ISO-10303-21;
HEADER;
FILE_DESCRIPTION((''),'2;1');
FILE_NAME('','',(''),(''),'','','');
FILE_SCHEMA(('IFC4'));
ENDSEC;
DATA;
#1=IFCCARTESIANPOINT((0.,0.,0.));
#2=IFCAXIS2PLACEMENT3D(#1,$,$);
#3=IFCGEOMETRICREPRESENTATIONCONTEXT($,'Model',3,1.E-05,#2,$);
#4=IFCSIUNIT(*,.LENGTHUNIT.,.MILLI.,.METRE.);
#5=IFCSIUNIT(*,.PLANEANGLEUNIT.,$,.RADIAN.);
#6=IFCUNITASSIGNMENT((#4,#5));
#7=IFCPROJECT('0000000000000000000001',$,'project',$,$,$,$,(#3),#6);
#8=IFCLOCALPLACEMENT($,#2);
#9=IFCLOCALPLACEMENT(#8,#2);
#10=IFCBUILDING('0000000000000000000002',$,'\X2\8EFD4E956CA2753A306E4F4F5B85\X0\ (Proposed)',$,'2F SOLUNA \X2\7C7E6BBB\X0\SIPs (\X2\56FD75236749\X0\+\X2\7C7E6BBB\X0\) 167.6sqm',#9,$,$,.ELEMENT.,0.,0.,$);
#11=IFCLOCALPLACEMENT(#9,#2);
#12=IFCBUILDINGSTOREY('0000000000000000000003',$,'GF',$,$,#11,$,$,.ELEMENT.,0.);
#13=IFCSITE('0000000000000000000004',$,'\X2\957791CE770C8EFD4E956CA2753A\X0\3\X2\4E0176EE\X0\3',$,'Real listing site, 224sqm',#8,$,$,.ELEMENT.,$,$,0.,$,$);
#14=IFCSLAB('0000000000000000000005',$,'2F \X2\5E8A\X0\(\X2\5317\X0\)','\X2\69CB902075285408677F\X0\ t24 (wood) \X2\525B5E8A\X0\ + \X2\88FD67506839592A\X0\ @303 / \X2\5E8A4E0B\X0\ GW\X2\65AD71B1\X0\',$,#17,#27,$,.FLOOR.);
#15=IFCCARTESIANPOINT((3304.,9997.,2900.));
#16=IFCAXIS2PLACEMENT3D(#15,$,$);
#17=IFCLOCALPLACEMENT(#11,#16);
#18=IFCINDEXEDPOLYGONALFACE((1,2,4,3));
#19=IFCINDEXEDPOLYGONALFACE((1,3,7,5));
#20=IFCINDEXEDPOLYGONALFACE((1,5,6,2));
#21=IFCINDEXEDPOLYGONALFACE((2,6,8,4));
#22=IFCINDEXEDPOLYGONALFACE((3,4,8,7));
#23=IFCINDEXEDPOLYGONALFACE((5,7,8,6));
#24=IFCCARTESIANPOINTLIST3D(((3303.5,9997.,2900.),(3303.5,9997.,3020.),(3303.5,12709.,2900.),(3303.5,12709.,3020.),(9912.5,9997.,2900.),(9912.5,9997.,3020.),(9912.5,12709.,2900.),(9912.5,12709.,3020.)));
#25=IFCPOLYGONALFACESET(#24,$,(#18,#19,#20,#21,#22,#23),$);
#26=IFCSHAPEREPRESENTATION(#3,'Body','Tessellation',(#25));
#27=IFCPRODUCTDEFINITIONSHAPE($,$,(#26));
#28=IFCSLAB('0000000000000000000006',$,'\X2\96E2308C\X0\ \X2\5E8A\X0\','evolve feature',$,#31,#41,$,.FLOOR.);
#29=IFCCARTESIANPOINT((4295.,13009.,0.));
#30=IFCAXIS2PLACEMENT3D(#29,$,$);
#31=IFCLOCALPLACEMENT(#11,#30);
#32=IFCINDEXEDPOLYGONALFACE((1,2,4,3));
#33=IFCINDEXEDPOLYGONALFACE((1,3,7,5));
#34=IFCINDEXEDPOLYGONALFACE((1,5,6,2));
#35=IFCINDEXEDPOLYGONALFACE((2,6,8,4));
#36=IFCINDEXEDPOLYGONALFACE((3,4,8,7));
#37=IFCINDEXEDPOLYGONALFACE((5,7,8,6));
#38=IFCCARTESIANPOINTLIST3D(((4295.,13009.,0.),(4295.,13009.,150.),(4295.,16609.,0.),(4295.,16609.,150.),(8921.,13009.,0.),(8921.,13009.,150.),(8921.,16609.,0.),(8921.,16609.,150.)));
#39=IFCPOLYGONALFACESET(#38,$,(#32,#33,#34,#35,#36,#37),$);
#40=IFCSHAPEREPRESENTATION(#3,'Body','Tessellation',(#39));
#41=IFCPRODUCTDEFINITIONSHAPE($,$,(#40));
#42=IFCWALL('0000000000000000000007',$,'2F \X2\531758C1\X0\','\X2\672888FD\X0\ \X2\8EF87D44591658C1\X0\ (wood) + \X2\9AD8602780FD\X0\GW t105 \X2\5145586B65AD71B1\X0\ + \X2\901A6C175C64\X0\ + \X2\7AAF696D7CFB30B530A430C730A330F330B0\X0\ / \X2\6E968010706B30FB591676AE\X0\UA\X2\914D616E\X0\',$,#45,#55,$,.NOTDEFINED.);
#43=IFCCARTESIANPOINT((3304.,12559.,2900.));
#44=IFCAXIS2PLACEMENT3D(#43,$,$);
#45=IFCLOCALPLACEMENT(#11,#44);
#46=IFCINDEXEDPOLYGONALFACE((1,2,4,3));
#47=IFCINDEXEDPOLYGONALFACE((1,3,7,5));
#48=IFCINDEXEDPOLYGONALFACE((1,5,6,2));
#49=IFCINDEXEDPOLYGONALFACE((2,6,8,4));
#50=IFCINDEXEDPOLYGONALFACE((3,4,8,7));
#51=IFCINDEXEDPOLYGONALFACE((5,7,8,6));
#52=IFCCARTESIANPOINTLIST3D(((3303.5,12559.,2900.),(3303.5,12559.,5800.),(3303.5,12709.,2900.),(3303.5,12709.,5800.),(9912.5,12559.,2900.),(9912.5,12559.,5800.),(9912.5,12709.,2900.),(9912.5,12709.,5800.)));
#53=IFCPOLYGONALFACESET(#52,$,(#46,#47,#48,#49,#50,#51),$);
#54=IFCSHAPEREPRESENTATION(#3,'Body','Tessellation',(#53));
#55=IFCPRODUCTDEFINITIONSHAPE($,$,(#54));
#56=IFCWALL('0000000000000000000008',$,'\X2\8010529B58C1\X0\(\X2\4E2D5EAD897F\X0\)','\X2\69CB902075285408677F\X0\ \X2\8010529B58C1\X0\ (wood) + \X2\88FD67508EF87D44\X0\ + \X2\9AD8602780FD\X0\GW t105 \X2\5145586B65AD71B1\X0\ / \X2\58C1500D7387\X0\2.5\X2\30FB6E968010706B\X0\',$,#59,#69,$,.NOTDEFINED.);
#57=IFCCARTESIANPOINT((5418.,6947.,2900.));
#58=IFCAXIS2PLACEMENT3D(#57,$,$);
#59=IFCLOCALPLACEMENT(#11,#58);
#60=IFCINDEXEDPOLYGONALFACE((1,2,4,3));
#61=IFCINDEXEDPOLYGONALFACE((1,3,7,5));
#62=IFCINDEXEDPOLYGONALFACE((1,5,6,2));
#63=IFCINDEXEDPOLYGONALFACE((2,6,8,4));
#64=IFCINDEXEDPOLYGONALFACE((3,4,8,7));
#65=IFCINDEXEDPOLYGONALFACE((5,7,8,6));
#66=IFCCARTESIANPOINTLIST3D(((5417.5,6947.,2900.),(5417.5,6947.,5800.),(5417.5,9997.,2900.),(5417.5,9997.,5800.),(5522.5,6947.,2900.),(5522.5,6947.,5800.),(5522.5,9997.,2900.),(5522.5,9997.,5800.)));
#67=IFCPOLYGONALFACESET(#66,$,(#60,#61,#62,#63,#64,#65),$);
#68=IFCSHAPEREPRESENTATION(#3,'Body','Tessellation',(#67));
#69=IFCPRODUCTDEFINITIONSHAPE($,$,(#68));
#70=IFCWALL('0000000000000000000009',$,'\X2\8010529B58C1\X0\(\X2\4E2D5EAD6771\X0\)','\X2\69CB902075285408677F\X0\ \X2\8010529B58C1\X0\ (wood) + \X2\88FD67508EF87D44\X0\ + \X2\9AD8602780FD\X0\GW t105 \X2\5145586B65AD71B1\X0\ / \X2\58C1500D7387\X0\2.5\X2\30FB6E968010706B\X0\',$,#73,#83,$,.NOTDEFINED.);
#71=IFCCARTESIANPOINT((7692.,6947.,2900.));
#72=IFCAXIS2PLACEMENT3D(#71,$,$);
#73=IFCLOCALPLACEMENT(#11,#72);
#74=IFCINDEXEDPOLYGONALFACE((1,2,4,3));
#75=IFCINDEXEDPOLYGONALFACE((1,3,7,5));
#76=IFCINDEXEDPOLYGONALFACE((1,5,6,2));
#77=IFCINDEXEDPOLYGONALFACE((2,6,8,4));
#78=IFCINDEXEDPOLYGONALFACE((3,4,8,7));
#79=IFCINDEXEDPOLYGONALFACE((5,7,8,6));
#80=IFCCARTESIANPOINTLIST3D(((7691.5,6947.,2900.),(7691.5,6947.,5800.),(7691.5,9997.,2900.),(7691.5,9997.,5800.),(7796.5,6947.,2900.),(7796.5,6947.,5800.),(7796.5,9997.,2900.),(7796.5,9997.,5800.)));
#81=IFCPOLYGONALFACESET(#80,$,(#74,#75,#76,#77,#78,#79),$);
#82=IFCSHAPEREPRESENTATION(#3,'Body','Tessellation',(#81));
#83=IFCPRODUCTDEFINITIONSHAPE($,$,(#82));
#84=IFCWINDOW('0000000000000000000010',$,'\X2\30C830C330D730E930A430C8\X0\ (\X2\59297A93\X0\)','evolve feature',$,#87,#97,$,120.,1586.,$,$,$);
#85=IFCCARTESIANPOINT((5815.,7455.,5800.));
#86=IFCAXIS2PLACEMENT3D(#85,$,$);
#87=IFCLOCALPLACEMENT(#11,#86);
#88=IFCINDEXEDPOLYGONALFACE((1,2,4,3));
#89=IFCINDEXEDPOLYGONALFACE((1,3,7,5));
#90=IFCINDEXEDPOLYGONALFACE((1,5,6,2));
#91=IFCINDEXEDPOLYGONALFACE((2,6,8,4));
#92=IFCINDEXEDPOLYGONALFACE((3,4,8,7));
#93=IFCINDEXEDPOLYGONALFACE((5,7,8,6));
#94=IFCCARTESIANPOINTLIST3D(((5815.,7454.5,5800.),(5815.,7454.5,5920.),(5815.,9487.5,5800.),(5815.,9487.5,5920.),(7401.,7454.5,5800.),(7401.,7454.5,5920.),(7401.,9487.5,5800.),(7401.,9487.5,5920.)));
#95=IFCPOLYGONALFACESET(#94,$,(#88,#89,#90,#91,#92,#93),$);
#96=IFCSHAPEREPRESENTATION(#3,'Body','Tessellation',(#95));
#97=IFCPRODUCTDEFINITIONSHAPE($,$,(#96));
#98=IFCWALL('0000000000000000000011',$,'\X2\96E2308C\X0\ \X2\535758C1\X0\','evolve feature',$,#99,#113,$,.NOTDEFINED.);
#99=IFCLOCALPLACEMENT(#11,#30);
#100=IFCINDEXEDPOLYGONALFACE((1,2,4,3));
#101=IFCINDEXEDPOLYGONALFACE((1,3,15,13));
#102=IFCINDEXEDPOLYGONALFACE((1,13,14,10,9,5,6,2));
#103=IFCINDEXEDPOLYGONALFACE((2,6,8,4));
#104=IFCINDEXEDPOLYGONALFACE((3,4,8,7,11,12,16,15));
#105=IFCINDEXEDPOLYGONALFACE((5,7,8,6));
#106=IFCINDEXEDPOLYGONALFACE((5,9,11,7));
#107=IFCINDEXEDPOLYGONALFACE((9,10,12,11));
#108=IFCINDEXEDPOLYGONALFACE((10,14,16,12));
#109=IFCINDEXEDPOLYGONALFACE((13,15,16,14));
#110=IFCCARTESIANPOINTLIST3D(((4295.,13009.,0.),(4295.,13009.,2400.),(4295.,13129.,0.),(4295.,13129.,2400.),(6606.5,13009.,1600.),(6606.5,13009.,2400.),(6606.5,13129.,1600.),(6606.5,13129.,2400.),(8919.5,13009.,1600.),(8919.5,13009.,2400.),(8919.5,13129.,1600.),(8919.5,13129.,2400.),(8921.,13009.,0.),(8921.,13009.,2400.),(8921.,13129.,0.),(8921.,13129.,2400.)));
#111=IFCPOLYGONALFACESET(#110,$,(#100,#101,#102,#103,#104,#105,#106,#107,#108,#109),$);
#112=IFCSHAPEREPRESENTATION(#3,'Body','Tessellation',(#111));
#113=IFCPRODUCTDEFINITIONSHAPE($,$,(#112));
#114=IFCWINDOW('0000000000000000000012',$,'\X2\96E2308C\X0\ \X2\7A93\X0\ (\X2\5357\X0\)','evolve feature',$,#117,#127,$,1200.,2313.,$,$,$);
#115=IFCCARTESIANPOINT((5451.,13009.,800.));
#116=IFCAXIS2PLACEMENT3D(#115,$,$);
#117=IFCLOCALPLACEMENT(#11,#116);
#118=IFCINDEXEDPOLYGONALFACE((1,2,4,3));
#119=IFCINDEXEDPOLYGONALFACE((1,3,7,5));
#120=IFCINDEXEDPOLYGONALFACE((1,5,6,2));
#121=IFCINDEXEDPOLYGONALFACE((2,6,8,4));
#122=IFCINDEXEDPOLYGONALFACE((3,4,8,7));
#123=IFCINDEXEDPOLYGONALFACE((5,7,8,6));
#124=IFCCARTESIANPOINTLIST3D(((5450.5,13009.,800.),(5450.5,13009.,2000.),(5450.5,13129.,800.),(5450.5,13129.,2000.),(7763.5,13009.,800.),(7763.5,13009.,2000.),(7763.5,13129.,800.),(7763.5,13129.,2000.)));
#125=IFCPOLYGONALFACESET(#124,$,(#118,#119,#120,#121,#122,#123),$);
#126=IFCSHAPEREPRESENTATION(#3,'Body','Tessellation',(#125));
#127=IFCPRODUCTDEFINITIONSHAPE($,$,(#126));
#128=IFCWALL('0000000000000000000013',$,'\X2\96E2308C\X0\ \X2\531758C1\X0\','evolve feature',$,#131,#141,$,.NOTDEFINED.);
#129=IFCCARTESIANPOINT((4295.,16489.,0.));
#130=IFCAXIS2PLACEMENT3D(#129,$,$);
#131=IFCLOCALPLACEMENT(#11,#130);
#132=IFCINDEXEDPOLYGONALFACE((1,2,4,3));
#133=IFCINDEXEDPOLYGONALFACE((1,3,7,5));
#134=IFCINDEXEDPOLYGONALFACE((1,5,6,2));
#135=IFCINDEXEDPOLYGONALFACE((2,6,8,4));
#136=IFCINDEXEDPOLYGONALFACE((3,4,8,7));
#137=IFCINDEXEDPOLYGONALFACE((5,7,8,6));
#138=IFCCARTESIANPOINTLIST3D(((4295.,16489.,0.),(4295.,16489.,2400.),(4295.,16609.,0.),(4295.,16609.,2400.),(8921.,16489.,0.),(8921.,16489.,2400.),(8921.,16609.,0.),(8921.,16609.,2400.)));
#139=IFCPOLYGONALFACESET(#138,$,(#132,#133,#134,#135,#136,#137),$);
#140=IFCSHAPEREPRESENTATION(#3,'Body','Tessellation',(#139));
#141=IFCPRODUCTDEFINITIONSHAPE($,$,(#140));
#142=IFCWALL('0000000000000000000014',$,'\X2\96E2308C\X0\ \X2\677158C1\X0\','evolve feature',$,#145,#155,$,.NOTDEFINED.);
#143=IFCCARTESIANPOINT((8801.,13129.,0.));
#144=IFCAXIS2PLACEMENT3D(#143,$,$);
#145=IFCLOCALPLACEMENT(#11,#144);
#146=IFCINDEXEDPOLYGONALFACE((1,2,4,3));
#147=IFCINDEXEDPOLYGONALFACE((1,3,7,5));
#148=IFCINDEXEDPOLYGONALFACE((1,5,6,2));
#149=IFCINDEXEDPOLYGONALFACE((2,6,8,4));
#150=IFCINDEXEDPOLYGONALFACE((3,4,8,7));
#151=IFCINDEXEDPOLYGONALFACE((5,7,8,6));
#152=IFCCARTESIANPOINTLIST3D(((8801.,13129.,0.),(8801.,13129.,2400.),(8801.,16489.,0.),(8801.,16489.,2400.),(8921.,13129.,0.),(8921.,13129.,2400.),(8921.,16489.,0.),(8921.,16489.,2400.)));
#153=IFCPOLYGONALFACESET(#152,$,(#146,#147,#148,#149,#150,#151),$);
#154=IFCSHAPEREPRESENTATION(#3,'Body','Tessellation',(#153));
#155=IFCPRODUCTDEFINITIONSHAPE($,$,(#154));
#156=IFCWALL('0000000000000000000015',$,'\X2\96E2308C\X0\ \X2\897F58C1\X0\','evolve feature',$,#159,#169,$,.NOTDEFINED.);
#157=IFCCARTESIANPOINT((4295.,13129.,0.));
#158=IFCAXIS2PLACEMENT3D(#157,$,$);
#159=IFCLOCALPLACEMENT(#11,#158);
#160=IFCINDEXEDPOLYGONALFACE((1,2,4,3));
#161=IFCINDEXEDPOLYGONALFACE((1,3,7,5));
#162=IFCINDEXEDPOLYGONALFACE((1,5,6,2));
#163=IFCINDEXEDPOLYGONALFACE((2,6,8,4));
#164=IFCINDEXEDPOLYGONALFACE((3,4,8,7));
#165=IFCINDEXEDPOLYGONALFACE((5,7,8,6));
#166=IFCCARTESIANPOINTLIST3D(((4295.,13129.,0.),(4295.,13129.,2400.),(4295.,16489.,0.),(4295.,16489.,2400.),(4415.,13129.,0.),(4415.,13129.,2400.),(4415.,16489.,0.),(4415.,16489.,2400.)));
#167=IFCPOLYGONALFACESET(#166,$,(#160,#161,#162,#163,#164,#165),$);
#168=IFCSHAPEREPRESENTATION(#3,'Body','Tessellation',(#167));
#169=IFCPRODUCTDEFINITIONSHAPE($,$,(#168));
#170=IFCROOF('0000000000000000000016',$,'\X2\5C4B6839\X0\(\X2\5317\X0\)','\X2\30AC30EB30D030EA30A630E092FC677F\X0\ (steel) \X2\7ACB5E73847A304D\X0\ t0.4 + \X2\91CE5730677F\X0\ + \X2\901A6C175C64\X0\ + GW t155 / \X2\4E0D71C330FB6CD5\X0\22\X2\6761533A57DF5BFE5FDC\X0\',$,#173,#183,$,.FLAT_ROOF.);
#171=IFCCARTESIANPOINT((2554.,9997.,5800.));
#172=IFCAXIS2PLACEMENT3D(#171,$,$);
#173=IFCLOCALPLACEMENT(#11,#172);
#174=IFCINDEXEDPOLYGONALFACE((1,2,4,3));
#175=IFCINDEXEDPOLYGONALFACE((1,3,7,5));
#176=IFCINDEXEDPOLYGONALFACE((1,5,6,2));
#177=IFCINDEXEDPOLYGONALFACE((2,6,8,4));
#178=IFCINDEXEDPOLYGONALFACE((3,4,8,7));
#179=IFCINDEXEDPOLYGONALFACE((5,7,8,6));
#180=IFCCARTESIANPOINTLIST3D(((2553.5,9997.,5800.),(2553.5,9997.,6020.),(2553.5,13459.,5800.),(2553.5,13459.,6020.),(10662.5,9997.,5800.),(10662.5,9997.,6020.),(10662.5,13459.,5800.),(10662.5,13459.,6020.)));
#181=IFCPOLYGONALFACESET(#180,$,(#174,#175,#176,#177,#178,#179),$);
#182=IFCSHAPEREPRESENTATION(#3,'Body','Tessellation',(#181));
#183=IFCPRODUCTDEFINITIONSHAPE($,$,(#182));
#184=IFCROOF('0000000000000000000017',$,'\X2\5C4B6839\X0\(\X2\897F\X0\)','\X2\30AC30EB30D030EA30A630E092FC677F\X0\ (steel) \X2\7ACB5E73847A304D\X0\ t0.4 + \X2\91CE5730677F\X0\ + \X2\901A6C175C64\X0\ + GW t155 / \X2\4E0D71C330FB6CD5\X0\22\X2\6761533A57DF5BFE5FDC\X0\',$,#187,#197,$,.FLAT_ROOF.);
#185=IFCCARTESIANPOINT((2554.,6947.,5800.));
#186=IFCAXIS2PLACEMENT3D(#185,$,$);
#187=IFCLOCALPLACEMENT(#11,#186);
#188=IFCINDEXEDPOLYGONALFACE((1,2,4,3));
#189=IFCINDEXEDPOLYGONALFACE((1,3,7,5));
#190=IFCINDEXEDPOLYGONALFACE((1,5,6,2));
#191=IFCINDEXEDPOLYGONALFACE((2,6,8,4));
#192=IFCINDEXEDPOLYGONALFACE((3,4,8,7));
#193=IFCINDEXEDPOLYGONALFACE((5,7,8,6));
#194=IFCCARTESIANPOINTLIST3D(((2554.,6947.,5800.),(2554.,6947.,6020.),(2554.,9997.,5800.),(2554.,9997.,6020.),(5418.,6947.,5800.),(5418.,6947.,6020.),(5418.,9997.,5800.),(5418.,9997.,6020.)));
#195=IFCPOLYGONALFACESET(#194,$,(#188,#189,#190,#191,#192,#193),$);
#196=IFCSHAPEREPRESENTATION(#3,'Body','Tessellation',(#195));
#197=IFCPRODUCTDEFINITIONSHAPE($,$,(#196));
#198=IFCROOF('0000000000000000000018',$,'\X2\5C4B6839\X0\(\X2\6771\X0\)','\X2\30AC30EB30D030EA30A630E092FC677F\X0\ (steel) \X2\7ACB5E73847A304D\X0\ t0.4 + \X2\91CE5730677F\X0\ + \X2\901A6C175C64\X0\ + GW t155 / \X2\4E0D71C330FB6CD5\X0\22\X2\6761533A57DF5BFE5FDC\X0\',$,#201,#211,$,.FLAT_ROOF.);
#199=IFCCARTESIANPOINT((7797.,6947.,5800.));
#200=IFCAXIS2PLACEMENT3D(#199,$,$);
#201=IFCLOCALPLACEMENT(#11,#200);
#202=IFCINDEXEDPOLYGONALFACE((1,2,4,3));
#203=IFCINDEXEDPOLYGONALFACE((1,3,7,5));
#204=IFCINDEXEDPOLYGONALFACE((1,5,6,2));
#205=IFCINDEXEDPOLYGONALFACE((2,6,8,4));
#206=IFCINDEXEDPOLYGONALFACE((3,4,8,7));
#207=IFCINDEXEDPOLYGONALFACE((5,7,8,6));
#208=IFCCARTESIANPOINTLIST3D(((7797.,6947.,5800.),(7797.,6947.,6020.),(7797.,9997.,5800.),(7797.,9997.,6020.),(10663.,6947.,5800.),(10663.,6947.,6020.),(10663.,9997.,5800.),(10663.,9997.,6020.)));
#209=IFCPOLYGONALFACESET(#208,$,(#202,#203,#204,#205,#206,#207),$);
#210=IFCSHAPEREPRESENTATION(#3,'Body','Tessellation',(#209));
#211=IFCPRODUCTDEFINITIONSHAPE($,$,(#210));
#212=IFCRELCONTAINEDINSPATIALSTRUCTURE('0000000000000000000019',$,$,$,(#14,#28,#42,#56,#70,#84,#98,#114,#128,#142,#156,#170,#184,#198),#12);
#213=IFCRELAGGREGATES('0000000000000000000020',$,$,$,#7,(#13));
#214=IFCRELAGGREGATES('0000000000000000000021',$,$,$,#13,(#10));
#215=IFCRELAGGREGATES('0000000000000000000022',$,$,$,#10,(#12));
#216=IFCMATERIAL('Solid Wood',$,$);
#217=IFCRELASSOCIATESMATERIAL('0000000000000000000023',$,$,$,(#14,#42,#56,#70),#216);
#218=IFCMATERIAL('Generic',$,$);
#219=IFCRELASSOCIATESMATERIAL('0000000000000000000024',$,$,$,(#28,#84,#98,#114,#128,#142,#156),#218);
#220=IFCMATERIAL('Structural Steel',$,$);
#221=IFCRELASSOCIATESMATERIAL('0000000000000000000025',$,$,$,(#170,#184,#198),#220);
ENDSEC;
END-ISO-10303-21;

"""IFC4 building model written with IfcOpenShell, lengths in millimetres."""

from ifc_helpers import new_model, si_unit, frame, frame_2d, origin, place, context, project, spatial, rectangle, extrude, material, element, fill, save


model = new_model("IFC4")

# Units and contexts
model_context = context("Model", 3, precision=1e-05, world=origin())
ifc_project = project(units=[si_unit("LENGTHUNIT", "METRE", prefix="MILLI"), si_unit("PLANEANGLEUNIT", "RADIAN")], contexts=[model_context])

# Site, building, storey
site_placement = place(None, origin())
site = spatial("IfcSite", under=ifc_project, at=site_placement, Name="長野県軽井沢町3丁目3", ObjectType="Real listing site, 224sqm", CompositionType="ELEMENT", RefElevation=0.0)
building_placement = place(site_placement, origin())
building = spatial("IfcBuilding", under=site, at=building_placement, Name="軽井沢町の住宅 (Proposed)", ObjectType="2F SOLUNA 籾殻SIPs (国産杉+籾殻) 167.6sqm", CompositionType="ELEMENT", ElevationOfRefHeight=0.0, ElevationOfTerrain=0.0)
storey_placement = place(building_placement, origin())
storey = spatial("IfcBuildingStorey", under=building, at=storey_placement, Name="GF", CompositionType="ELEMENT", Elevation=0.0)

# Slabs
ifc_material_1 = material(Name="Solid Wood")
slab_1_placement = place(storey_placement, frame((3304.0, 9997.0, 2900.0)))
element("IfcSlab", 1, at=slab_1_placement, inside=storey, material=ifc_material_1, Name="2F 床(北)", Description="構造用合板 t24 (wood) 剛床 + 製材根太 @303 / 床下 GW断熱", PredefinedType="FLOOR", context=model_context, shape_type="SweptSolid", body=[
    extrude(rectangle(XDim=6609.0, YDim=2712.0, at=frame_2d((3304.0, 1356.0))), frame((3304.0, 9997.0, 2900.0)), (0.0, 0.0, 1.0), 120.0),
])
ifc_material_2 = material(Name="Generic")
slab_2_placement = place(storey_placement, frame((4295.0, 13009.0, 0.0)))
element("IfcSlab", 2, at=slab_2_placement, inside=storey, material=ifc_material_2, Name="離れ 床", Description="evolve feature", PredefinedType="FLOOR", context=model_context, shape_type="SweptSolid", body=[
    extrude(rectangle(XDim=4626.0, YDim=3600.0, at=frame_2d((2313.0, 1800.0))), frame((4295.0, 13009.0, 0.0)), (0.0, 0.0, 1.0), 150.0),
])

# Wall
wall_1_placement = place(storey_placement, frame((3304.0, 12559.0, 2900.0)))
element("IfcWall", 3, at=wall_1_placement, inside=storey, material=ifc_material_1, Name="2F 北壁", Description="木製 軸組外壁 (wood) + 高性能GW t105 充填断熱 + 通気層 + 窯業系サイディング / 準耐火・外皮UA配慮", PredefinedType="NOTDEFINED", context=model_context, shape_type="SweptSolid", body=[
    extrude(rectangle(XDim=6609.0, YDim=150.0, at=frame_2d((3304.0, 75.0))), frame((3304.0, 12559.0, 2900.0)), (0.0, 0.0, 1.0), 2900.0),
])

# Walls
wall_2_placement = place(storey_placement, frame((5418.0, 6947.0, 2900.0)))
element("IfcWall", 4, at=wall_2_placement, inside=storey, material=ifc_material_1, Name="耐力壁(中庭西)", Description="構造用合板 耐力壁 (wood) + 製材軸組 + 高性能GW t105 充填断熱 / 壁倍率2.5・準耐火", PredefinedType="NOTDEFINED", context=model_context, shape_type="SweptSolid", body=[
    extrude(rectangle(XDim=105.0, YDim=3050.0, at=frame_2d((52.0, 1525.0))), frame((5418.0, 6947.0, 2900.0)), (0.0, 0.0, 1.0), 2900.0),
])
wall_3_placement = place(storey_placement, frame((7692.0, 6947.0, 2900.0)))
element("IfcWall", 5, at=wall_3_placement, inside=storey, material=ifc_material_1, Name="耐力壁(中庭東)", Description="構造用合板 耐力壁 (wood) + 製材軸組 + 高性能GW t105 充填断熱 / 壁倍率2.5・準耐火", PredefinedType="NOTDEFINED", context=model_context, shape_type="SweptSolid", body=[
    extrude(rectangle(XDim=105.0, YDim=3050.0, at=frame_2d((52.0, 1525.0))), frame((7692.0, 6947.0, 2900.0)), (0.0, 0.0, 1.0), 2900.0),
])

# Window
window_1_placement = place(storey_placement, frame((5815.0, 7455.0, 5800.0)))
element("IfcWindow", 6, at=window_1_placement, inside=storey, material=ifc_material_2, Name="トップライト (天窓)", Description="evolve feature", OverallHeight=120.0, OverallWidth=1586.0, context=model_context, shape_type="SweptSolid", body=[
    extrude(rectangle(XDim=1586.0, YDim=2033.0, at=frame_2d((793.0, 1016.0))), frame((5815.0, 7455.0, 5800.0)), (0.0, 0.0, 1.0), 120.0),
])

# Wall, opening, window
wall_4_placement = place(storey_placement, frame((4295.0, 13009.0, 0.0)))
wall_4 = element("IfcWall", 7, at=wall_4_placement, inside=storey, material=ifc_material_2, Name="離れ 南壁", Description="evolve feature", PredefinedType="NOTDEFINED", context=model_context, shape_type="SweptSolid", body=[
    extrude(rectangle(XDim=4626.0, YDim=120.0, at=frame_2d((2313.0, 60.0))), frame((4295.0, 13009.0, 0.0)), (0.0, 0.0, 1.0), 2400.0),
])
opening_1_placement = place(storey_placement, frame((5451.0, 13009.0, 800.0)))
opening_1 = element("IfcOpeningElement", 8, at=opening_1_placement, cuts=wall_4, PredefinedType="NOTDEFINED", context=model_context, shape_type="SweptSolid", body=[
    extrude(rectangle(XDim=2313.0, YDim=120.0, at=frame_2d((1156.0, 60.0))), frame((5451.0, 13009.0, 800.0)), (0.0, 0.0, 1.0), 1200.0),
])
window_2_placement = place(storey_placement, frame((5451.0, 13009.0, 800.0)))
window_2 = element("IfcWindow", 9, at=window_2_placement, inside=storey, material=ifc_material_2, Name="離れ 窓 (南)", Description="evolve feature", OverallHeight=1200.0, OverallWidth=2313.0, context=model_context, shape_type="SweptSolid", body=[
    extrude(rectangle(XDim=2313.0, YDim=120.0, at=frame_2d((1156.0, 60.0))), frame((5451.0, 13009.0, 800.0)), (0.0, 0.0, 1.0), 1200.0),
])
fill(opening_1, window_2)

# Walls
wall_5_placement = place(storey_placement, frame((4295.0, 16489.0, 0.0)))
element("IfcWall", 10, at=wall_5_placement, inside=storey, material=ifc_material_2, Name="離れ 北壁", Description="evolve feature", PredefinedType="NOTDEFINED", context=model_context, shape_type="SweptSolid", body=[
    extrude(rectangle(XDim=4626.0, YDim=120.0, at=frame_2d((2313.0, 60.0))), frame((4295.0, 16489.0, 0.0)), (0.0, 0.0, 1.0), 2400.0),
])
wall_6_placement = place(storey_placement, frame((8801.0, 13129.0, 0.0)))
element("IfcWall", 11, at=wall_6_placement, inside=storey, material=ifc_material_2, Name="離れ 東壁", Description="evolve feature", PredefinedType="NOTDEFINED", context=model_context, shape_type="SweptSolid", body=[
    extrude(rectangle(XDim=120.0, YDim=3360.0, at=frame_2d((60.0, 1680.0))), frame((8801.0, 13129.0, 0.0)), (0.0, 0.0, 1.0), 2400.0),
])
wall_7_placement = place(storey_placement, frame((4295.0, 13129.0, 0.0)))
element("IfcWall", 12, at=wall_7_placement, inside=storey, material=ifc_material_2, Name="離れ 西壁", Description="evolve feature", PredefinedType="NOTDEFINED", context=model_context, shape_type="SweptSolid", body=[
    extrude(rectangle(XDim=120.0, YDim=3360.0, at=frame_2d((60.0, 1680.0))), frame((4295.0, 13129.0, 0.0)), (0.0, 0.0, 1.0), 2400.0),
])

# Roofs
ifc_material_3 = material(Name="Structural Steel")
for number, where, name in (
    (13, (2554.0, 9997.0, 5800.0), "屋根(北)"),
):
    element("IfcRoof", number, at=place(storey_placement, frame(where)), inside=storey, material=ifc_material_3, Name=name, Description="ガルバリウム鋼板 (steel) 立平葺き t0.4 + 野地板 + 通気層 + GW t155 / 不燃・法22条区域対応", PredefinedType="FLAT_ROOF", context=model_context, shape_type="SweptSolid", body=[
        extrude(rectangle(XDim=8109.0, YDim=3462.0, at=frame_2d((4054.0, 1731.0))), frame((2554.0, 9997.0, 5800.0)), (0.0, 0.0, 1.0), 220.0),
    ])
roof_1_placement = place(storey_placement, frame((2554.0, 6947.0, 5800.0)))
element("IfcRoof", 14, at=roof_1_placement, inside=storey, material=ifc_material_3, Name="屋根(西)", Description="ガルバリウム鋼板 (steel) 立平葺き t0.4 + 野地板 + 通気層 + GW t155 / 不燃・法22条区域対応", PredefinedType="FLAT_ROOF", context=model_context, shape_type="SweptSolid", body=[
    extrude(rectangle(XDim=2864.0, YDim=3050.0, at=frame_2d((1432.0, 1525.0))), frame((2554.0, 6947.0, 5800.0)), (0.0, 0.0, 1.0), 220.0),
])
roof_2_placement = place(storey_placement, frame((7797.0, 6947.0, 5800.0)))
element("IfcRoof", 15, at=roof_2_placement, inside=storey, material=ifc_material_3, Name="屋根(東)", Description="ガルバリウム鋼板 (steel) 立平葺き t0.4 + 野地板 + 通気層 + GW t155 / 不燃・法22条区域対応", PredefinedType="FLAT_ROOF", context=model_context, shape_type="SweptSolid", body=[
    extrude(rectangle(XDim=2866.0, YDim=3050.0, at=frame_2d((1433.0, 1525.0))), frame((7797.0, 6947.0, 5800.0)), (0.0, 0.0, 1.0), 220.0),
])

save(model, "model.ifc")
